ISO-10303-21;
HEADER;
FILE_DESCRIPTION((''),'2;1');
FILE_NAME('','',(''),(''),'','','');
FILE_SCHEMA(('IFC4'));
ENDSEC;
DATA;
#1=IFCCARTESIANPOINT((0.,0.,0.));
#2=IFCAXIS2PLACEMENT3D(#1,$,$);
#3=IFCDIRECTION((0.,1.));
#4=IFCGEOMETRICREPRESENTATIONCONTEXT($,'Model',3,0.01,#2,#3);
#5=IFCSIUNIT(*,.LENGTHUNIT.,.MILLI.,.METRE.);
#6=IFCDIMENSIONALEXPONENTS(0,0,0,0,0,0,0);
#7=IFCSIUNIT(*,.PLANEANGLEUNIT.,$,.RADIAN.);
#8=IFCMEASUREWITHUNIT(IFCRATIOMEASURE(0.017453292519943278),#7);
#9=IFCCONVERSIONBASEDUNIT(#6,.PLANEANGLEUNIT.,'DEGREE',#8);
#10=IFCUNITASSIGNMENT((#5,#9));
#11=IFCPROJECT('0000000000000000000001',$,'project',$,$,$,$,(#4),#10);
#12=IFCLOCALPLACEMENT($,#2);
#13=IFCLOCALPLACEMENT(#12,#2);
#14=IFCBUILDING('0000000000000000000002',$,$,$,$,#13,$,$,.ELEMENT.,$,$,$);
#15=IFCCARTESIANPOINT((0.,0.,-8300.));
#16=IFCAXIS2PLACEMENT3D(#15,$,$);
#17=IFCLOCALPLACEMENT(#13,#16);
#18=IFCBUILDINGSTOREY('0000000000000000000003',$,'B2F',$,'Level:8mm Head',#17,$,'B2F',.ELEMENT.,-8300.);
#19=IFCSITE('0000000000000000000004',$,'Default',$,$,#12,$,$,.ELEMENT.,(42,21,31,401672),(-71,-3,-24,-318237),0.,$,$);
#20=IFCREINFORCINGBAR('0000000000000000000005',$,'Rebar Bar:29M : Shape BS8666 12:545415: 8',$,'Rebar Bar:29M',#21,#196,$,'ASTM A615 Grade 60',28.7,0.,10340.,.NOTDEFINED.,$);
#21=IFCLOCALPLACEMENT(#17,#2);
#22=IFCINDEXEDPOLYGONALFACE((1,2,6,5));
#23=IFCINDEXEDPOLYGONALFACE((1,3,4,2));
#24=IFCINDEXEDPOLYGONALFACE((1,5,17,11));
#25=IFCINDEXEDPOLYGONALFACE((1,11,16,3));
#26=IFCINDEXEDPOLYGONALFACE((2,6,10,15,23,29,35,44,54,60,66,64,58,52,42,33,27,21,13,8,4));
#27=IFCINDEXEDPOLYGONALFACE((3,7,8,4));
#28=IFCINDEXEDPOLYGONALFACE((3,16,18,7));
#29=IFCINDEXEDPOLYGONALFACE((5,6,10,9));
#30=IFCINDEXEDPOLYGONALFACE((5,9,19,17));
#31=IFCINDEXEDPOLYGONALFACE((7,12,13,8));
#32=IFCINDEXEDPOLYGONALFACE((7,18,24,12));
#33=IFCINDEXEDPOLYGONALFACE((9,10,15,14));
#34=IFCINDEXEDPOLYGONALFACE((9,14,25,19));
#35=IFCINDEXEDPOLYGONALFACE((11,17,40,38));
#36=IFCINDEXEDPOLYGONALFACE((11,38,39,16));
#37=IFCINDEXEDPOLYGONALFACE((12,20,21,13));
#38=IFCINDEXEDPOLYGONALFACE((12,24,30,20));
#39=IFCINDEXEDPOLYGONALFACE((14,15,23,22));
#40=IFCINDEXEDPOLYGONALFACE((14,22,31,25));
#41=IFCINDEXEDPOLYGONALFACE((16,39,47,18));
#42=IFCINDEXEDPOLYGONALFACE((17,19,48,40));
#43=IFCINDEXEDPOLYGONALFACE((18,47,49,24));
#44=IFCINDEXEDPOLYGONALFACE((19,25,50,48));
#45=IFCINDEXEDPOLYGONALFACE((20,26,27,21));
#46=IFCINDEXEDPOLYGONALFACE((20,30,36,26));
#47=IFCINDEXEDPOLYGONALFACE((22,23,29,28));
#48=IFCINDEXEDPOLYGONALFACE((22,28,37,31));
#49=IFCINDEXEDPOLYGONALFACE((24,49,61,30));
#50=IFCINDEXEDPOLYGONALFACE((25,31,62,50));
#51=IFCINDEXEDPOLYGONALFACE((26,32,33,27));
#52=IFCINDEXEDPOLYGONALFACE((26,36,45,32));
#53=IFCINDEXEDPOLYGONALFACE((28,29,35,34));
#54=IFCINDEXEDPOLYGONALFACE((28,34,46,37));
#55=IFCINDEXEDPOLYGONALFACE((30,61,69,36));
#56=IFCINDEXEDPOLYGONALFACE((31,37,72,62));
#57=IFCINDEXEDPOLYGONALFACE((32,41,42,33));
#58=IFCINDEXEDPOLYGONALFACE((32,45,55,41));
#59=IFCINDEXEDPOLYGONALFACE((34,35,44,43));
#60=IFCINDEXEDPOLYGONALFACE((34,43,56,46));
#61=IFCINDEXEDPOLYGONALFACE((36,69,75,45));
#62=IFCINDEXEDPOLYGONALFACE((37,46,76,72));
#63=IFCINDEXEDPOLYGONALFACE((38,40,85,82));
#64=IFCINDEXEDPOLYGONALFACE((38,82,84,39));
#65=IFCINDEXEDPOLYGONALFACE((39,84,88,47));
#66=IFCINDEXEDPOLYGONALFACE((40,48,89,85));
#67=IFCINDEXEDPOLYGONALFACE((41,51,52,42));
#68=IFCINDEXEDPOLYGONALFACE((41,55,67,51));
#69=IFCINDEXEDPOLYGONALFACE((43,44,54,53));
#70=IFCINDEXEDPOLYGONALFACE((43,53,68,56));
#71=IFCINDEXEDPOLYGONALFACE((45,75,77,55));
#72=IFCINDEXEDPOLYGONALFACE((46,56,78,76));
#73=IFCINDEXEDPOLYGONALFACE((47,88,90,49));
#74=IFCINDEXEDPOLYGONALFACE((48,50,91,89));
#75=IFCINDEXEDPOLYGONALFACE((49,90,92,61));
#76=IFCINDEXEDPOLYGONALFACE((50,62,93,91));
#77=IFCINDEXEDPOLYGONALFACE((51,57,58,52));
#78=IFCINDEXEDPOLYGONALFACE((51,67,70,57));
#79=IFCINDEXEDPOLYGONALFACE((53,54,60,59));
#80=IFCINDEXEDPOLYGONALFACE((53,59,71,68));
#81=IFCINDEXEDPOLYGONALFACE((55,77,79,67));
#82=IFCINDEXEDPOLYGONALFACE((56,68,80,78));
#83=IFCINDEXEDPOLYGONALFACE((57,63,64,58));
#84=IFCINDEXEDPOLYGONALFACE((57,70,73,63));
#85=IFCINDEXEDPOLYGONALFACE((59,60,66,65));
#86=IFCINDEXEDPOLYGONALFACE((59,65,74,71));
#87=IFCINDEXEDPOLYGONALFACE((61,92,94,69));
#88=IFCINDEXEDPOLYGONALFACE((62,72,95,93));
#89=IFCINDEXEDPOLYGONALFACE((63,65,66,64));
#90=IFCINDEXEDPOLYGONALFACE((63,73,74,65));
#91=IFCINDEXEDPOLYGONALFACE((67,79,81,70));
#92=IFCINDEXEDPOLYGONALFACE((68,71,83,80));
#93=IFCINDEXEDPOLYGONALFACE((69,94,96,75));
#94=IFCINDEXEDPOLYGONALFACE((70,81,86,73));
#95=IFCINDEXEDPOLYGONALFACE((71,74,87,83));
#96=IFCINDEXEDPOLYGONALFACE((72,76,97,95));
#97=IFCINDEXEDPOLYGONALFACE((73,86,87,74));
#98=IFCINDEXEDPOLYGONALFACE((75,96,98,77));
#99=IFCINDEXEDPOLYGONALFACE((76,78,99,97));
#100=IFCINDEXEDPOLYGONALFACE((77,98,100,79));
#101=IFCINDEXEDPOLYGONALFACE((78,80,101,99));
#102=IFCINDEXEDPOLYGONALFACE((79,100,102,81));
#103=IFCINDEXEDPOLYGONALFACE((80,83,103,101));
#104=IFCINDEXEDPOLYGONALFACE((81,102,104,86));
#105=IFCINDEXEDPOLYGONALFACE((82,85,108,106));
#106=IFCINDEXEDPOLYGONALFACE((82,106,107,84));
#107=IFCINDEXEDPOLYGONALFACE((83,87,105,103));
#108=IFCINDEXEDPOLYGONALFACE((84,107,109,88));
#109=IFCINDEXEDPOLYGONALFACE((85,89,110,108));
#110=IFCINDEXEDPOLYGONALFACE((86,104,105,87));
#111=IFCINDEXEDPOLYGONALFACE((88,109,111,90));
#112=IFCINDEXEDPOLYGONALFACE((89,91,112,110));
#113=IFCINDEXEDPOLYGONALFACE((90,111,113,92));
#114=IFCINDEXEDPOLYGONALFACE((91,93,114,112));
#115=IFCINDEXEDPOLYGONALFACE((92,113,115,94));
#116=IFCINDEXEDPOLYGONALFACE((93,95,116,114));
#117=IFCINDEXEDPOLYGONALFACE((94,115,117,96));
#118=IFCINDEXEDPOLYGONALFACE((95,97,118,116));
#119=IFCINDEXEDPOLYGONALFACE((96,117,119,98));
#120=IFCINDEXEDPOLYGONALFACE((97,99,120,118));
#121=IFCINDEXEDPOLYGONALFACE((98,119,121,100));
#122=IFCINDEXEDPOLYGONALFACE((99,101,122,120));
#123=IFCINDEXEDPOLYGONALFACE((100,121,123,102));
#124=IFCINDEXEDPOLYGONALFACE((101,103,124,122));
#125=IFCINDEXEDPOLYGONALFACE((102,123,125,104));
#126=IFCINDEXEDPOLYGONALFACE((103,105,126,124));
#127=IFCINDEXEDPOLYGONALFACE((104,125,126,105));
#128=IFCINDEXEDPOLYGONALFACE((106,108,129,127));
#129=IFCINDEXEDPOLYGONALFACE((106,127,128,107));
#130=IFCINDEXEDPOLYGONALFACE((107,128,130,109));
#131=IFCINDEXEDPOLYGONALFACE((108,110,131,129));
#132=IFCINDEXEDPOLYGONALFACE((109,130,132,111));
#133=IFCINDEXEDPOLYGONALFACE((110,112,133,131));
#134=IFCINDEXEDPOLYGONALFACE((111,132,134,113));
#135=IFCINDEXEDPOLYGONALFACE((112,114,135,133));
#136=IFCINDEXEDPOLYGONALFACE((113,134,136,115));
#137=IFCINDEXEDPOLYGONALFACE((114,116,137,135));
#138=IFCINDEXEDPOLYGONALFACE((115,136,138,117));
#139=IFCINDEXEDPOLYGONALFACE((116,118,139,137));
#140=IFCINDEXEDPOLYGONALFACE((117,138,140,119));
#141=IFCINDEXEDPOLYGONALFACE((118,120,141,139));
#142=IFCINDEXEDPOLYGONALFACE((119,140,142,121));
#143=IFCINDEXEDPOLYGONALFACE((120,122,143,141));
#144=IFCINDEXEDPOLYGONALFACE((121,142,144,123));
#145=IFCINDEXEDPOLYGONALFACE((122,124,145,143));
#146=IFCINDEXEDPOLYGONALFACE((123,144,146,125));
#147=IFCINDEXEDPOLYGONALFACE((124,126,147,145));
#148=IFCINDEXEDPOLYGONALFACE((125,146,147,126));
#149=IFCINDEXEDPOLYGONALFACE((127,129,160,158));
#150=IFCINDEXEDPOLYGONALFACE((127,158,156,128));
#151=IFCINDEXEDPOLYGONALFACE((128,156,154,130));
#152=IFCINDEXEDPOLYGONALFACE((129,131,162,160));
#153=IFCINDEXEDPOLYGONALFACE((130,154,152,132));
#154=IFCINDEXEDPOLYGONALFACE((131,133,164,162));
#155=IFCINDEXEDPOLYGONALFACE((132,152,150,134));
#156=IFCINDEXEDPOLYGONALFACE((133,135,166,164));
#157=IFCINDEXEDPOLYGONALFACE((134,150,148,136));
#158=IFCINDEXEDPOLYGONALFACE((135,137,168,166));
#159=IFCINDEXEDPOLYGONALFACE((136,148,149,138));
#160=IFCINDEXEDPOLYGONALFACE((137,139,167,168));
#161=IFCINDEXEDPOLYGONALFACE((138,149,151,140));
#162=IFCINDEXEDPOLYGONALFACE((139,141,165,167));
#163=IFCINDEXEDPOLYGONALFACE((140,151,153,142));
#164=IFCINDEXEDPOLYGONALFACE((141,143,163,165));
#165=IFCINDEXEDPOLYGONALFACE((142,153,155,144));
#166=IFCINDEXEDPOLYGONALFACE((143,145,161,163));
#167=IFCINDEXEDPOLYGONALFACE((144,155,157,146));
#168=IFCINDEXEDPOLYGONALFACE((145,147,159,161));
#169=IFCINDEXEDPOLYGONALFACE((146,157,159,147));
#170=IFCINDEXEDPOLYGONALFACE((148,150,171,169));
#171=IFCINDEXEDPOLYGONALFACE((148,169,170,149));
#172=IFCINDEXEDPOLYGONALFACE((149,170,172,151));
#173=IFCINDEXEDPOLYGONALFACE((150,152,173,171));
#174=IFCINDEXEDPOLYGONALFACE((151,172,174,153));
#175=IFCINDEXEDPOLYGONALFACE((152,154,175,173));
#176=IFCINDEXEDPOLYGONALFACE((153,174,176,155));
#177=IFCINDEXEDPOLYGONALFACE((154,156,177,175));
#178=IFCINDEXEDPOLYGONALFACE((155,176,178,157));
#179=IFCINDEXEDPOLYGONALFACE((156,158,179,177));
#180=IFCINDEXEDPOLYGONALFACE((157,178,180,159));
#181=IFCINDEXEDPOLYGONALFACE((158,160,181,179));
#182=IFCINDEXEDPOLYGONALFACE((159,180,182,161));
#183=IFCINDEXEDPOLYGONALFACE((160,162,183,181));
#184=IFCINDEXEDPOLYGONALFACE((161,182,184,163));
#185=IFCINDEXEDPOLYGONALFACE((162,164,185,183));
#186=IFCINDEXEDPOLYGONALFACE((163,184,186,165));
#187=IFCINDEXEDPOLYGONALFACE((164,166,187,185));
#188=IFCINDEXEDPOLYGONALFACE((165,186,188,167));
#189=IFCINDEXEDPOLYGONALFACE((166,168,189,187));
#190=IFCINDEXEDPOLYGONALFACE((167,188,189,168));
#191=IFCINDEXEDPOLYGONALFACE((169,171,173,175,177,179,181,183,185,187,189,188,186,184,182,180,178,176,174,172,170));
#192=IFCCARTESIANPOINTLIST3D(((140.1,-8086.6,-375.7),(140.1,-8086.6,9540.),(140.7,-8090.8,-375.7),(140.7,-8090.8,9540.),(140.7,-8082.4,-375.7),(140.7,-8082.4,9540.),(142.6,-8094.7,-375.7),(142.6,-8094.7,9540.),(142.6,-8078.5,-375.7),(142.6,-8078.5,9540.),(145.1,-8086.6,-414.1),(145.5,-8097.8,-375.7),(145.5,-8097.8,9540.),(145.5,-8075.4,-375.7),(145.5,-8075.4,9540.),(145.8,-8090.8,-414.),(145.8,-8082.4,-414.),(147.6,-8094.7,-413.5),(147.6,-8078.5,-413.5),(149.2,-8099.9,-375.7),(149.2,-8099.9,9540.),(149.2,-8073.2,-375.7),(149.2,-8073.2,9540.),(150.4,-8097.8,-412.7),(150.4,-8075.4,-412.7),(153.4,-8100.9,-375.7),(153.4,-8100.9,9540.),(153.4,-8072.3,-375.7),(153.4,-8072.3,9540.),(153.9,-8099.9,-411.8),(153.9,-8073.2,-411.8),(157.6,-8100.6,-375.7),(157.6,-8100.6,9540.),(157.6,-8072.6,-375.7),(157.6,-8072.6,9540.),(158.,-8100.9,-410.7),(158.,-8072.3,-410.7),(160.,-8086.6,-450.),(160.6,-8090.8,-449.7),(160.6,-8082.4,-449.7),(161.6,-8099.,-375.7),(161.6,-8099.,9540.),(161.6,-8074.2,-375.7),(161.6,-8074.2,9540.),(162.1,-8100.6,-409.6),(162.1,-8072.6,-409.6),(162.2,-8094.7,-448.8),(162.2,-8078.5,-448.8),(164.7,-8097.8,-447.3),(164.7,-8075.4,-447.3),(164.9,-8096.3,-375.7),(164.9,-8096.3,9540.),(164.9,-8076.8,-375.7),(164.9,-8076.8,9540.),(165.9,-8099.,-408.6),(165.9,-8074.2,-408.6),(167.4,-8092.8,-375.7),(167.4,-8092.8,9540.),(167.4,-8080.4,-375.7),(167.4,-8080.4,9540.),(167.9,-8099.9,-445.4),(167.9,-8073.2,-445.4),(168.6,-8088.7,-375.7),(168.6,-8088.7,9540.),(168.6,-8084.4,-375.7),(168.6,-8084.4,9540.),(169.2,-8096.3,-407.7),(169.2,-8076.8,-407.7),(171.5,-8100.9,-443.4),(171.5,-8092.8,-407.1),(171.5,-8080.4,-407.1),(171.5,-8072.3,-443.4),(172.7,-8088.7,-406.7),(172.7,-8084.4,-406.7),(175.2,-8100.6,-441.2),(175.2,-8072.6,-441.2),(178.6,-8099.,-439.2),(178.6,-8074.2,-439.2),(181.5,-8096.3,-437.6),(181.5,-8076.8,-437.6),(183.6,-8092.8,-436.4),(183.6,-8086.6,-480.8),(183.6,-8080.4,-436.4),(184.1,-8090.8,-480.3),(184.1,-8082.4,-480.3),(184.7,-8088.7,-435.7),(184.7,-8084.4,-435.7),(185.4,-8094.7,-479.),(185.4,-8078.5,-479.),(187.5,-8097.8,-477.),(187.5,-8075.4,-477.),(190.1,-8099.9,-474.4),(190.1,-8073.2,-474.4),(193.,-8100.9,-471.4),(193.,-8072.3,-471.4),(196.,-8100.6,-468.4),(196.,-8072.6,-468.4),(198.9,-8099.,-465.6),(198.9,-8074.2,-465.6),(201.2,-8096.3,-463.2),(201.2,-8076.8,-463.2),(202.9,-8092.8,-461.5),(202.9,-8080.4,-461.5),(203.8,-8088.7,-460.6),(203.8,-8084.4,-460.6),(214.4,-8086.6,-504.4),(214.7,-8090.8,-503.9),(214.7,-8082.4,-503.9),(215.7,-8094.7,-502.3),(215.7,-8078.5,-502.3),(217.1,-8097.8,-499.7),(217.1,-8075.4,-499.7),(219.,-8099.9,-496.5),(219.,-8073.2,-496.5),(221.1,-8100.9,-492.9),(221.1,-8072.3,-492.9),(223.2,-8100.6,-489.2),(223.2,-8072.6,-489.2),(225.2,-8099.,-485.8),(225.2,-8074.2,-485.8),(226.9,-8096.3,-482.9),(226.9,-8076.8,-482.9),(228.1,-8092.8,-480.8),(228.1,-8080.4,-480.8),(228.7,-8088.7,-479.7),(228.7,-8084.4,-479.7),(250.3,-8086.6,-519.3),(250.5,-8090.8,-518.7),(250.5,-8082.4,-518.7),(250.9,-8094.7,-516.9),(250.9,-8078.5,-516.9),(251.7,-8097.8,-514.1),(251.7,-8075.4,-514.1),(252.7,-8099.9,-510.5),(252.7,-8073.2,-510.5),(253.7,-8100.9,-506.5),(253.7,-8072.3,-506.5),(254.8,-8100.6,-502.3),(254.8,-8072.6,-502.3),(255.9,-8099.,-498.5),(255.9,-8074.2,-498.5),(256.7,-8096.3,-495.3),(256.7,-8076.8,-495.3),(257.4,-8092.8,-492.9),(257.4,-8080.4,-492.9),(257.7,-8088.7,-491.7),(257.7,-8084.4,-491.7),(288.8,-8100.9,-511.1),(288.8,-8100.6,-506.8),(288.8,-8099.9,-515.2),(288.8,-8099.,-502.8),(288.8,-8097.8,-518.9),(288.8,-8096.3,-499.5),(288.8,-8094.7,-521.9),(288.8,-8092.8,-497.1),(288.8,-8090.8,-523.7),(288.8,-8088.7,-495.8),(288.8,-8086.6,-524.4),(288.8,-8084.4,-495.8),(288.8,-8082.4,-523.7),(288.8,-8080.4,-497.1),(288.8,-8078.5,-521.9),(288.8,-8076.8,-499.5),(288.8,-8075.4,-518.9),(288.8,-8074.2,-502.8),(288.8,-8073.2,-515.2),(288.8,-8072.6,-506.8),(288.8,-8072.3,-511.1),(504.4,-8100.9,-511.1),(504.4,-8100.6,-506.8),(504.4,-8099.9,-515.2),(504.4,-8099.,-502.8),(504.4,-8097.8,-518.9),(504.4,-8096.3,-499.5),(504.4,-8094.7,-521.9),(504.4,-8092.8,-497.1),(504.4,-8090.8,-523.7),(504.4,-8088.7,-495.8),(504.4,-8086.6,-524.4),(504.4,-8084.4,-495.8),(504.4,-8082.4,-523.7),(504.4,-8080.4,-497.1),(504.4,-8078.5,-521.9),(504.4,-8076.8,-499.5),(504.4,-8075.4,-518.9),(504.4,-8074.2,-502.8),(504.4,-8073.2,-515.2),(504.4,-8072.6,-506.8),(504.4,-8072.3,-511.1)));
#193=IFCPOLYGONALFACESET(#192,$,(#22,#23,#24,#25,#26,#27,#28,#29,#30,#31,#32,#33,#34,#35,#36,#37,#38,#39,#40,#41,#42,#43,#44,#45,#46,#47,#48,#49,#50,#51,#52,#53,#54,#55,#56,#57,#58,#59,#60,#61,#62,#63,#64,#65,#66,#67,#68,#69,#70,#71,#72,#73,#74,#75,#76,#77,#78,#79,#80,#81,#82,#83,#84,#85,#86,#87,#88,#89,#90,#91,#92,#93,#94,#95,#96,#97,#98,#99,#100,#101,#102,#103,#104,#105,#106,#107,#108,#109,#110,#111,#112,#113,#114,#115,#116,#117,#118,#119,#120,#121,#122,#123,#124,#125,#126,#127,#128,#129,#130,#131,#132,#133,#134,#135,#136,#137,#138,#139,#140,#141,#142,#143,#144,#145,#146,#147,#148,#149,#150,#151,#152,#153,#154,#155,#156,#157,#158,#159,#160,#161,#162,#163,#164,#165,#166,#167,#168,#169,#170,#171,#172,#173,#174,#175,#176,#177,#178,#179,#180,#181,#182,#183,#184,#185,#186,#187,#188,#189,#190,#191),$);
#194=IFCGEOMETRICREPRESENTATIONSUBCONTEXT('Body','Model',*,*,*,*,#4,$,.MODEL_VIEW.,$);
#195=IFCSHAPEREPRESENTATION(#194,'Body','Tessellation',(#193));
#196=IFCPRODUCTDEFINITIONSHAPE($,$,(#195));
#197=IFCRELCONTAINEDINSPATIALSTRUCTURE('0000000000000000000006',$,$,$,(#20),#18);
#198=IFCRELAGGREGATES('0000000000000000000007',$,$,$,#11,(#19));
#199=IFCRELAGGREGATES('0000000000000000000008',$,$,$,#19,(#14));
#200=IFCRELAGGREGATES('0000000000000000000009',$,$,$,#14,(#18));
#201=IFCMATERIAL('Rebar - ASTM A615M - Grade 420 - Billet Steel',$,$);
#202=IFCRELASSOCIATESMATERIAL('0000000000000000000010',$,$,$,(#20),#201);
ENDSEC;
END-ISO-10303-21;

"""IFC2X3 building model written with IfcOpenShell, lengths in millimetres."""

from ifc_helpers import new_model, entity, si_unit, converted_unit, direction, frame, origin, place, context, subcontext, project, spatial, material, element, save


model = new_model("IFC2X3")

# Units and contexts
model_context = context("Model", 3, precision=0.01, world=origin(), true_north=direction((0.0, 1.0)))
body_context = subcontext(model_context, "Body", "Model", "MODEL_VIEW")
ifc_project = project(units=[si_unit("LENGTHUNIT", "METRE", prefix="MILLI"), converted_unit("PLANEANGLEUNIT", "DEGREE", entity("IfcRatioMeasure", 0.017453292519943278), si_unit("PLANEANGLEUNIT", "RADIAN"), dimensions=[0, 0, 0, 0, 0, 0, 0])], contexts=[model_context])

# Site, building, storey
site_placement = place(None, origin())
site = spatial("IfcSite", under=ifc_project, at=site_placement, Name="Default", CompositionType="ELEMENT", RefLatitude=(42, 21, 31, 401672), RefLongitude=(-71, -3, -24, -318237), RefElevation=0.0)
building_placement = place(site_placement, origin())
building = spatial("IfcBuilding", under=site, at=building_placement, CompositionType="ELEMENT")
storey_placement = place(building_placement, frame((0.0, 0.0, -8300.0)))
storey = spatial("IfcBuildingStorey", under=building, at=storey_placement, Name="B2F", ObjectType="Level:8mm Head", LongName="B2F", CompositionType="ELEMENT", Elevation=-8300.0)

# Reinforcing bar
ifc_material_1 = material(Name="Rebar - ASTM A615M - Grade 420 - Billet Steel")
reinforcing_bar_1_placement = place(storey_placement, origin())
element("IfcReinforcingBar", 1, at=reinforcing_bar_1_placement, inside=storey, material=ifc_material_1, Name="Rebar Bar:29M : Shape BS8666 12:545415: 8", SteelGrade="ASTM A615 Grade 60", ObjectType="Rebar Bar:29M", BarLength=10340.0, BarRole="NOTDEFINED", CrossSectionArea=0.0, NominalDiameter=28.7, context=body_context, shape_type="AdvancedSweptSolid", body=[
    entity("IfcSweptDiskSolid", entity("IfcCompositeCurve", [entity("IfcCompositeCurveSegment", "CONTINUOUS", True, entity("IfcPolyline", [entity("IfcCartesianPoint", [154.4, -8086.6, 9540.0]), entity("IfcCartesianPoint", [154.4, -8086.6, -375.7])])), entity("IfcCompositeCurveSegment", "CONTINUOUS", True, entity("IfcTrimmedCurve", entity("IfcCircle", entity("IfcAxis2Placement3D", entity("IfcCartesianPoint", [288.8, -8086.6, -375.7]), entity("IfcDirection", [0.0, -1.0, 0.0]), entity("IfcDirection", [0.0, 0.0, -1.0])), 134.3), [entity("IfcParameterValue", 270.0)], [entity("IfcParameterValue", 360.0)], True, "PARAMETER")), entity("IfcCompositeCurveSegment", "CONTINUOUS", True, entity("IfcPolyline", [entity("IfcCartesianPoint", [288.8, -8086.6, -510.0]), entity("IfcCartesianPoint", [504.4, -8086.6, -510.0])]))], False), 14.3, None, 0.0, 92.0),
])

save(model, "model.ifc")
